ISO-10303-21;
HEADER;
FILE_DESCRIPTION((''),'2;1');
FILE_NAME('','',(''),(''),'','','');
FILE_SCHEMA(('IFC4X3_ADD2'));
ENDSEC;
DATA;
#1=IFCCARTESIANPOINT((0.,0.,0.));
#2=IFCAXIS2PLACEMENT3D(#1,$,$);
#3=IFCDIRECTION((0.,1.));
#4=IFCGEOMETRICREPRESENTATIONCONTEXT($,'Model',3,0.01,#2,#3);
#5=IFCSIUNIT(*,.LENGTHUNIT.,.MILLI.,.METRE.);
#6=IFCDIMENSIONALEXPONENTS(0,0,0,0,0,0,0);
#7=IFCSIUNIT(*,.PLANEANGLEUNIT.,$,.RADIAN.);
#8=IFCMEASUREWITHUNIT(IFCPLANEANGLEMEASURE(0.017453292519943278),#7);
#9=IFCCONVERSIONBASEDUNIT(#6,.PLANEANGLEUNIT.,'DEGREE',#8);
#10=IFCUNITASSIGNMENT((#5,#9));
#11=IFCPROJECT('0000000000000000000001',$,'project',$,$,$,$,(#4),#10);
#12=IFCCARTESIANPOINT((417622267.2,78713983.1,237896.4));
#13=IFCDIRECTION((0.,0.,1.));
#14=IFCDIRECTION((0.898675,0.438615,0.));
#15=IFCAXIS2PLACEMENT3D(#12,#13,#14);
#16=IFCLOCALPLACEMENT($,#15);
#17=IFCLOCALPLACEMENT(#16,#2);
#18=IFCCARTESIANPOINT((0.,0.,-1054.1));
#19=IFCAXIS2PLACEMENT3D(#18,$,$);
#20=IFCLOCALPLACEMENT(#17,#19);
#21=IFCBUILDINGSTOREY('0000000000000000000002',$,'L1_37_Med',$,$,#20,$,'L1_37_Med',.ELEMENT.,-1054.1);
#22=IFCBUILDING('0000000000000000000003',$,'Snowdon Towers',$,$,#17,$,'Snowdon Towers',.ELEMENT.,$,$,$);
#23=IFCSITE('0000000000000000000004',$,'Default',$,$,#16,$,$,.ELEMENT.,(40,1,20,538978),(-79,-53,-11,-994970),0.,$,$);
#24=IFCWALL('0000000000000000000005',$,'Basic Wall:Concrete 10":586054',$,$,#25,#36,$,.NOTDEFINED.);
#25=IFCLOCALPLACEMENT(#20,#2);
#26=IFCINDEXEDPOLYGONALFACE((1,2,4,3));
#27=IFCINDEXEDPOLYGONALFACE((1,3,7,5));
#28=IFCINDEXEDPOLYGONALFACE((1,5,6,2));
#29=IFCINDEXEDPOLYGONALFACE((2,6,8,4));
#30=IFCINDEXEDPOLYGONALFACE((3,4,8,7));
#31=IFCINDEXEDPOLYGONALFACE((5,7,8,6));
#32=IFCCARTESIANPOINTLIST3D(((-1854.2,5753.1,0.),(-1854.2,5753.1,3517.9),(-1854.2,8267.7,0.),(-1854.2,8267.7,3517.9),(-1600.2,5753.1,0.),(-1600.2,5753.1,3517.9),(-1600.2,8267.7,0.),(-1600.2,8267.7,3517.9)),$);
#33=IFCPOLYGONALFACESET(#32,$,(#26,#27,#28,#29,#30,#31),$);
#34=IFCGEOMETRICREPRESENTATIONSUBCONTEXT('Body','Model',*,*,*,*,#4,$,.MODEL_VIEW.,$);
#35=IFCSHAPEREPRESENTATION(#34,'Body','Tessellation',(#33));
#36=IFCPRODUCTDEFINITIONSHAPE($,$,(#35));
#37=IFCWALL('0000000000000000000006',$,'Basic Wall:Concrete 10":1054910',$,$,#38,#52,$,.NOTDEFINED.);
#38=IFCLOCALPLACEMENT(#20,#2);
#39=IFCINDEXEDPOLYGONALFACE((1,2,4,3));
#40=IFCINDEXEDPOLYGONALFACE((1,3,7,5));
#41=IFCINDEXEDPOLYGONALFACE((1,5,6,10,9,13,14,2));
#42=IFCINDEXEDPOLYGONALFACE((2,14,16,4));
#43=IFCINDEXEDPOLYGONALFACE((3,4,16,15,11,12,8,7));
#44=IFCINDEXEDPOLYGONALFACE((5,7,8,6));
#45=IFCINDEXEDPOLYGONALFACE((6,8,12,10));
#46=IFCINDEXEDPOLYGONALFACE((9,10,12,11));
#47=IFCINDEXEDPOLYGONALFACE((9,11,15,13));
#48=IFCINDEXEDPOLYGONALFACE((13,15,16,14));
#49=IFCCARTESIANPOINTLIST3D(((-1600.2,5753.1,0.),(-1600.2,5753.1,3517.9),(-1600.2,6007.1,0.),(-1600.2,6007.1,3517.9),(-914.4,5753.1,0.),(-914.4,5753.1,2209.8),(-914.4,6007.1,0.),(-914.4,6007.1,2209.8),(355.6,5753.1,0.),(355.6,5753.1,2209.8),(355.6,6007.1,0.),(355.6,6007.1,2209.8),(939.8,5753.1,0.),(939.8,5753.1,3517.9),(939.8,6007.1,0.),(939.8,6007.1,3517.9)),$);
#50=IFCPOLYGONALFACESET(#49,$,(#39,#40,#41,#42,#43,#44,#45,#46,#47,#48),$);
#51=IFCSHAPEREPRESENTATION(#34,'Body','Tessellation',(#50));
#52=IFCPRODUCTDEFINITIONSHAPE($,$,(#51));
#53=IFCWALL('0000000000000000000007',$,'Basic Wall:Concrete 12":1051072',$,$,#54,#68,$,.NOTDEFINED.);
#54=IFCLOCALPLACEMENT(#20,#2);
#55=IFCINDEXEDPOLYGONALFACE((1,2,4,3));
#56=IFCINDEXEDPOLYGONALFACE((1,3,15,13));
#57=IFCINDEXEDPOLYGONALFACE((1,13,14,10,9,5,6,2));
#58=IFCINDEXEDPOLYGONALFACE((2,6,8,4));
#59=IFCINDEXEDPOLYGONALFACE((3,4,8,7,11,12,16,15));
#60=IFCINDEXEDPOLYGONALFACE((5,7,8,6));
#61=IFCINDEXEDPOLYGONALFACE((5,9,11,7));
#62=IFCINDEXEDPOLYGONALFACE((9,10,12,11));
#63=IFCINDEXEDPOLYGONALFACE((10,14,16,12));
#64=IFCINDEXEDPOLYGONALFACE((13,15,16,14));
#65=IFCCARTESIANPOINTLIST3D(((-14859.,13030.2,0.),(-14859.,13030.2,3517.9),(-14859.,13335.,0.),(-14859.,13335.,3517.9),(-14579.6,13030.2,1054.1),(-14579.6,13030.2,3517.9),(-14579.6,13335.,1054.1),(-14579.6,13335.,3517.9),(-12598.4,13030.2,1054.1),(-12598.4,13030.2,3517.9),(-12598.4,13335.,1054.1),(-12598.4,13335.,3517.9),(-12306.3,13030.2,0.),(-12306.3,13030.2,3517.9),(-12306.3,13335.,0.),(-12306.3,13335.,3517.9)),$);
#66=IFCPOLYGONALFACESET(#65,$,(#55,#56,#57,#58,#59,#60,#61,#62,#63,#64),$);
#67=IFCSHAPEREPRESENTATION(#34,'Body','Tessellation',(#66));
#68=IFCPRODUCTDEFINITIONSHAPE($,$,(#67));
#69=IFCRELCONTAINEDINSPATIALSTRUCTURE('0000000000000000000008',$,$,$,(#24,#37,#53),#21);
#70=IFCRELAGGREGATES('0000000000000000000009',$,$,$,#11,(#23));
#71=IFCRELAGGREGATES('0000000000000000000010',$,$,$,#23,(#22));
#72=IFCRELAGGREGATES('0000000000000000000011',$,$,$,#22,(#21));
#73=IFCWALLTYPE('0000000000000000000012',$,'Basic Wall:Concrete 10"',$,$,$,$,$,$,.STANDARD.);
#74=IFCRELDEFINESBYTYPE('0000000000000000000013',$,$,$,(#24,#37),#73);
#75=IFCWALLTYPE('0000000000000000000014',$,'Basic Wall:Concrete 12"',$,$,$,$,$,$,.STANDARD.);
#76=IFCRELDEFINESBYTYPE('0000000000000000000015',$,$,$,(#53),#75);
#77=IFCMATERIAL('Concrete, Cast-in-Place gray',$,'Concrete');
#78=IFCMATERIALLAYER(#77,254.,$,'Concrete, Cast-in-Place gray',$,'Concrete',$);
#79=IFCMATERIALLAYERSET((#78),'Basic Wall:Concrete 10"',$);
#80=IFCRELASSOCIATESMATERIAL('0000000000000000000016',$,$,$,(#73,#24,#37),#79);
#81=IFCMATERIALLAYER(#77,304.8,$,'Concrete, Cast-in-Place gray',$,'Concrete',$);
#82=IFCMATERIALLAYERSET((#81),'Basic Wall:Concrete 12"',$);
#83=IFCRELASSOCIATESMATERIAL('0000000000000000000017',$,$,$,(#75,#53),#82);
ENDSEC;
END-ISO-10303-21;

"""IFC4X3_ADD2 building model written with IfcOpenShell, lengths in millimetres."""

from ifc_helpers import new_model, entity, si_unit, converted_unit, direction, frame, frame_2d, origin, place, context, subcontext, project, spatial, rectangle, extrude, material, layer, layer_set, type_object, element, save


model = new_model("IFC4X3_ADD2")

# Units and contexts
model_context = context("Model", 3, precision=0.01, world=origin(), true_north=direction((0.0, 1.0)))
body_context = subcontext(model_context, "Body", "Model", "MODEL_VIEW")
ifc_project = project(units=[si_unit("LENGTHUNIT", "METRE", prefix="MILLI"), converted_unit("PLANEANGLEUNIT", "DEGREE", entity("IfcPlaneAngleMeasure", 0.017453292519943278), si_unit("PLANEANGLEUNIT", "RADIAN"), dimensions=[0, 0, 0, 0, 0, 0, 0])], contexts=[model_context])

# Site, building, storey
site_placement = place(None, frame((417622267.2, 78713983.1, 237896.4), z_axis=(0.0, 0.0, 1.0), x_axis=(0.898675, 0.438615, 0.0)))
site = spatial("IfcSite", under=ifc_project, at=site_placement, Name="Default", CompositionType="ELEMENT", RefLatitude=(40, 1, 20, 538978), RefLongitude=(-79, -53, -11, -994970), RefElevation=0.0)
building_placement = place(site_placement, origin())
building = spatial("IfcBuilding", under=site, at=building_placement, Name="Snowdon Towers", LongName="Snowdon Towers", CompositionType="ELEMENT")
storey_placement = place(building_placement, frame((0.0, 0.0, -1054.1)))
storey = spatial("IfcBuildingStorey", under=building, at=storey_placement, Name="L1_37_Med", LongName="L1_37_Med", CompositionType="ELEMENT", Elevation=-1054.1)

# Shared definitions
ifc_material_1 = material(Name="Concrete, Cast-in-Place gray", Category="Concrete")

# Wall
ifc_layer_1 = layer(ifc_material_1, 254.0, Name="Concrete, Cast-in-Place gray", Category="Concrete")
ifc_layer_set_1 = layer_set([ifc_layer_1], Name="Basic Wall:Concrete 10\"")
wall_type_1 = type_object("IfcWallType", Name="Basic Wall:Concrete 10\"", PredefinedType="STANDARD", material=ifc_layer_set_1)
wall_1_placement = place(storey_placement, frame((-1727.2, 5753.1, 0.0), z_axis=(0.0, 0.0, 1.0), x_axis=(0.0, 1.0, 0.0)))
element("IfcWall", 1, at=wall_1_placement, inside=storey, type_object=wall_type_1, material=ifc_layer_set_1, Name="Basic Wall:Concrete 10\":586054", PredefinedType="NOTDEFINED", context=body_context, shape_type="SweptSolid", body=[
    extrude(rectangle(XDim=2514.6, YDim=254.0, at=frame_2d((1257.3, 0.0), x_axis=(-1.0, 0.0))), origin(), (0.0, 0.0, 1.0), 3517.9),
])

# Walls, openings
wall_2_placement = place(storey_placement, frame((939.8, 5880.1, 0.0), z_axis=(0.0, 0.0, 1.0), x_axis=(-1.0, 0.0, 0.0)))
wall_2 = element("IfcWall", 2, at=wall_2_placement, inside=storey, type_object=wall_type_1, material=ifc_layer_set_1, Name="Basic Wall:Concrete 10\":1054910", PredefinedType="NOTDEFINED", context=body_context, shape_type="SweptSolid", body=[
    extrude(rectangle(XDim=2540.0, YDim=254.0, at=frame_2d((1270.0, 0.0), x_axis=(-1.0, 0.0))), origin(), (0.0, 0.0, 1.0), 3517.9),
])
opening_1_placement = place(wall_2_placement, origin())
element("IfcOpeningElement", 3, at=opening_1_placement, cuts=wall_2, PredefinedType="OPENING", context=body_context, shape_type="SweptSolid", body=[
    extrude(rectangle(XDim=2209.8, YDim=1270.0, at=frame_2d((0.0, 0.0), x_axis=(0.0, 1.0))), frame((1219.2, 127.0, 1104.9), z_axis=(0.0, -1.0, 0.0), x_axis=(1.0, 0.0, 0.0)), (0.0, 0.0, 1.0), 254.0),
])
ifc_layer_2 = layer(ifc_material_1, 304.8, Name="Concrete, Cast-in-Place gray", Category="Concrete")
ifc_layer_set_2 = layer_set([ifc_layer_2], Name="Basic Wall:Concrete 12\"")
wall_type_2 = type_object("IfcWallType", Name="Basic Wall:Concrete 12\"", PredefinedType="STANDARD", material=ifc_layer_set_2)
wall_3_placement = place(storey_placement, frame((-12306.3, 13182.6, 0.0), z_axis=(0.0, 0.0, 1.0), x_axis=(-1.0, 0.0, 0.0)))
wall_3 = element("IfcWall", 4, at=wall_3_placement, inside=storey, type_object=wall_type_2, material=ifc_layer_set_2, Name="Basic Wall:Concrete 12\":1051072", PredefinedType="NOTDEFINED", context=body_context, shape_type="SweptSolid", body=[
    extrude(rectangle(XDim=2552.7, YDim=304.8, at=frame_2d((1276.3, 0.0), x_axis=(-1.0, 0.0))), origin(), (0.0, 0.0, 1.0), 3517.9),
])
opening_2_placement = place(wall_3_placement, origin())
element("IfcOpeningElement", 5, at=opening_2_placement, cuts=wall_3, PredefinedType="OPENING", context=body_context, shape_type="SweptSolid", body=[
    extrude(rectangle(XDim=2463.8, YDim=1981.2, at=frame_2d((0.0, 0.0), x_axis=(0.0, 1.0))), frame((1282.7, 152.4, 2286.0), z_axis=(0.0, -1.0, 0.0), x_axis=(-1.0, 0.0, 0.0)), (0.0, 0.0, 1.0), 304.8),
])

save(model, "model.ifc")
